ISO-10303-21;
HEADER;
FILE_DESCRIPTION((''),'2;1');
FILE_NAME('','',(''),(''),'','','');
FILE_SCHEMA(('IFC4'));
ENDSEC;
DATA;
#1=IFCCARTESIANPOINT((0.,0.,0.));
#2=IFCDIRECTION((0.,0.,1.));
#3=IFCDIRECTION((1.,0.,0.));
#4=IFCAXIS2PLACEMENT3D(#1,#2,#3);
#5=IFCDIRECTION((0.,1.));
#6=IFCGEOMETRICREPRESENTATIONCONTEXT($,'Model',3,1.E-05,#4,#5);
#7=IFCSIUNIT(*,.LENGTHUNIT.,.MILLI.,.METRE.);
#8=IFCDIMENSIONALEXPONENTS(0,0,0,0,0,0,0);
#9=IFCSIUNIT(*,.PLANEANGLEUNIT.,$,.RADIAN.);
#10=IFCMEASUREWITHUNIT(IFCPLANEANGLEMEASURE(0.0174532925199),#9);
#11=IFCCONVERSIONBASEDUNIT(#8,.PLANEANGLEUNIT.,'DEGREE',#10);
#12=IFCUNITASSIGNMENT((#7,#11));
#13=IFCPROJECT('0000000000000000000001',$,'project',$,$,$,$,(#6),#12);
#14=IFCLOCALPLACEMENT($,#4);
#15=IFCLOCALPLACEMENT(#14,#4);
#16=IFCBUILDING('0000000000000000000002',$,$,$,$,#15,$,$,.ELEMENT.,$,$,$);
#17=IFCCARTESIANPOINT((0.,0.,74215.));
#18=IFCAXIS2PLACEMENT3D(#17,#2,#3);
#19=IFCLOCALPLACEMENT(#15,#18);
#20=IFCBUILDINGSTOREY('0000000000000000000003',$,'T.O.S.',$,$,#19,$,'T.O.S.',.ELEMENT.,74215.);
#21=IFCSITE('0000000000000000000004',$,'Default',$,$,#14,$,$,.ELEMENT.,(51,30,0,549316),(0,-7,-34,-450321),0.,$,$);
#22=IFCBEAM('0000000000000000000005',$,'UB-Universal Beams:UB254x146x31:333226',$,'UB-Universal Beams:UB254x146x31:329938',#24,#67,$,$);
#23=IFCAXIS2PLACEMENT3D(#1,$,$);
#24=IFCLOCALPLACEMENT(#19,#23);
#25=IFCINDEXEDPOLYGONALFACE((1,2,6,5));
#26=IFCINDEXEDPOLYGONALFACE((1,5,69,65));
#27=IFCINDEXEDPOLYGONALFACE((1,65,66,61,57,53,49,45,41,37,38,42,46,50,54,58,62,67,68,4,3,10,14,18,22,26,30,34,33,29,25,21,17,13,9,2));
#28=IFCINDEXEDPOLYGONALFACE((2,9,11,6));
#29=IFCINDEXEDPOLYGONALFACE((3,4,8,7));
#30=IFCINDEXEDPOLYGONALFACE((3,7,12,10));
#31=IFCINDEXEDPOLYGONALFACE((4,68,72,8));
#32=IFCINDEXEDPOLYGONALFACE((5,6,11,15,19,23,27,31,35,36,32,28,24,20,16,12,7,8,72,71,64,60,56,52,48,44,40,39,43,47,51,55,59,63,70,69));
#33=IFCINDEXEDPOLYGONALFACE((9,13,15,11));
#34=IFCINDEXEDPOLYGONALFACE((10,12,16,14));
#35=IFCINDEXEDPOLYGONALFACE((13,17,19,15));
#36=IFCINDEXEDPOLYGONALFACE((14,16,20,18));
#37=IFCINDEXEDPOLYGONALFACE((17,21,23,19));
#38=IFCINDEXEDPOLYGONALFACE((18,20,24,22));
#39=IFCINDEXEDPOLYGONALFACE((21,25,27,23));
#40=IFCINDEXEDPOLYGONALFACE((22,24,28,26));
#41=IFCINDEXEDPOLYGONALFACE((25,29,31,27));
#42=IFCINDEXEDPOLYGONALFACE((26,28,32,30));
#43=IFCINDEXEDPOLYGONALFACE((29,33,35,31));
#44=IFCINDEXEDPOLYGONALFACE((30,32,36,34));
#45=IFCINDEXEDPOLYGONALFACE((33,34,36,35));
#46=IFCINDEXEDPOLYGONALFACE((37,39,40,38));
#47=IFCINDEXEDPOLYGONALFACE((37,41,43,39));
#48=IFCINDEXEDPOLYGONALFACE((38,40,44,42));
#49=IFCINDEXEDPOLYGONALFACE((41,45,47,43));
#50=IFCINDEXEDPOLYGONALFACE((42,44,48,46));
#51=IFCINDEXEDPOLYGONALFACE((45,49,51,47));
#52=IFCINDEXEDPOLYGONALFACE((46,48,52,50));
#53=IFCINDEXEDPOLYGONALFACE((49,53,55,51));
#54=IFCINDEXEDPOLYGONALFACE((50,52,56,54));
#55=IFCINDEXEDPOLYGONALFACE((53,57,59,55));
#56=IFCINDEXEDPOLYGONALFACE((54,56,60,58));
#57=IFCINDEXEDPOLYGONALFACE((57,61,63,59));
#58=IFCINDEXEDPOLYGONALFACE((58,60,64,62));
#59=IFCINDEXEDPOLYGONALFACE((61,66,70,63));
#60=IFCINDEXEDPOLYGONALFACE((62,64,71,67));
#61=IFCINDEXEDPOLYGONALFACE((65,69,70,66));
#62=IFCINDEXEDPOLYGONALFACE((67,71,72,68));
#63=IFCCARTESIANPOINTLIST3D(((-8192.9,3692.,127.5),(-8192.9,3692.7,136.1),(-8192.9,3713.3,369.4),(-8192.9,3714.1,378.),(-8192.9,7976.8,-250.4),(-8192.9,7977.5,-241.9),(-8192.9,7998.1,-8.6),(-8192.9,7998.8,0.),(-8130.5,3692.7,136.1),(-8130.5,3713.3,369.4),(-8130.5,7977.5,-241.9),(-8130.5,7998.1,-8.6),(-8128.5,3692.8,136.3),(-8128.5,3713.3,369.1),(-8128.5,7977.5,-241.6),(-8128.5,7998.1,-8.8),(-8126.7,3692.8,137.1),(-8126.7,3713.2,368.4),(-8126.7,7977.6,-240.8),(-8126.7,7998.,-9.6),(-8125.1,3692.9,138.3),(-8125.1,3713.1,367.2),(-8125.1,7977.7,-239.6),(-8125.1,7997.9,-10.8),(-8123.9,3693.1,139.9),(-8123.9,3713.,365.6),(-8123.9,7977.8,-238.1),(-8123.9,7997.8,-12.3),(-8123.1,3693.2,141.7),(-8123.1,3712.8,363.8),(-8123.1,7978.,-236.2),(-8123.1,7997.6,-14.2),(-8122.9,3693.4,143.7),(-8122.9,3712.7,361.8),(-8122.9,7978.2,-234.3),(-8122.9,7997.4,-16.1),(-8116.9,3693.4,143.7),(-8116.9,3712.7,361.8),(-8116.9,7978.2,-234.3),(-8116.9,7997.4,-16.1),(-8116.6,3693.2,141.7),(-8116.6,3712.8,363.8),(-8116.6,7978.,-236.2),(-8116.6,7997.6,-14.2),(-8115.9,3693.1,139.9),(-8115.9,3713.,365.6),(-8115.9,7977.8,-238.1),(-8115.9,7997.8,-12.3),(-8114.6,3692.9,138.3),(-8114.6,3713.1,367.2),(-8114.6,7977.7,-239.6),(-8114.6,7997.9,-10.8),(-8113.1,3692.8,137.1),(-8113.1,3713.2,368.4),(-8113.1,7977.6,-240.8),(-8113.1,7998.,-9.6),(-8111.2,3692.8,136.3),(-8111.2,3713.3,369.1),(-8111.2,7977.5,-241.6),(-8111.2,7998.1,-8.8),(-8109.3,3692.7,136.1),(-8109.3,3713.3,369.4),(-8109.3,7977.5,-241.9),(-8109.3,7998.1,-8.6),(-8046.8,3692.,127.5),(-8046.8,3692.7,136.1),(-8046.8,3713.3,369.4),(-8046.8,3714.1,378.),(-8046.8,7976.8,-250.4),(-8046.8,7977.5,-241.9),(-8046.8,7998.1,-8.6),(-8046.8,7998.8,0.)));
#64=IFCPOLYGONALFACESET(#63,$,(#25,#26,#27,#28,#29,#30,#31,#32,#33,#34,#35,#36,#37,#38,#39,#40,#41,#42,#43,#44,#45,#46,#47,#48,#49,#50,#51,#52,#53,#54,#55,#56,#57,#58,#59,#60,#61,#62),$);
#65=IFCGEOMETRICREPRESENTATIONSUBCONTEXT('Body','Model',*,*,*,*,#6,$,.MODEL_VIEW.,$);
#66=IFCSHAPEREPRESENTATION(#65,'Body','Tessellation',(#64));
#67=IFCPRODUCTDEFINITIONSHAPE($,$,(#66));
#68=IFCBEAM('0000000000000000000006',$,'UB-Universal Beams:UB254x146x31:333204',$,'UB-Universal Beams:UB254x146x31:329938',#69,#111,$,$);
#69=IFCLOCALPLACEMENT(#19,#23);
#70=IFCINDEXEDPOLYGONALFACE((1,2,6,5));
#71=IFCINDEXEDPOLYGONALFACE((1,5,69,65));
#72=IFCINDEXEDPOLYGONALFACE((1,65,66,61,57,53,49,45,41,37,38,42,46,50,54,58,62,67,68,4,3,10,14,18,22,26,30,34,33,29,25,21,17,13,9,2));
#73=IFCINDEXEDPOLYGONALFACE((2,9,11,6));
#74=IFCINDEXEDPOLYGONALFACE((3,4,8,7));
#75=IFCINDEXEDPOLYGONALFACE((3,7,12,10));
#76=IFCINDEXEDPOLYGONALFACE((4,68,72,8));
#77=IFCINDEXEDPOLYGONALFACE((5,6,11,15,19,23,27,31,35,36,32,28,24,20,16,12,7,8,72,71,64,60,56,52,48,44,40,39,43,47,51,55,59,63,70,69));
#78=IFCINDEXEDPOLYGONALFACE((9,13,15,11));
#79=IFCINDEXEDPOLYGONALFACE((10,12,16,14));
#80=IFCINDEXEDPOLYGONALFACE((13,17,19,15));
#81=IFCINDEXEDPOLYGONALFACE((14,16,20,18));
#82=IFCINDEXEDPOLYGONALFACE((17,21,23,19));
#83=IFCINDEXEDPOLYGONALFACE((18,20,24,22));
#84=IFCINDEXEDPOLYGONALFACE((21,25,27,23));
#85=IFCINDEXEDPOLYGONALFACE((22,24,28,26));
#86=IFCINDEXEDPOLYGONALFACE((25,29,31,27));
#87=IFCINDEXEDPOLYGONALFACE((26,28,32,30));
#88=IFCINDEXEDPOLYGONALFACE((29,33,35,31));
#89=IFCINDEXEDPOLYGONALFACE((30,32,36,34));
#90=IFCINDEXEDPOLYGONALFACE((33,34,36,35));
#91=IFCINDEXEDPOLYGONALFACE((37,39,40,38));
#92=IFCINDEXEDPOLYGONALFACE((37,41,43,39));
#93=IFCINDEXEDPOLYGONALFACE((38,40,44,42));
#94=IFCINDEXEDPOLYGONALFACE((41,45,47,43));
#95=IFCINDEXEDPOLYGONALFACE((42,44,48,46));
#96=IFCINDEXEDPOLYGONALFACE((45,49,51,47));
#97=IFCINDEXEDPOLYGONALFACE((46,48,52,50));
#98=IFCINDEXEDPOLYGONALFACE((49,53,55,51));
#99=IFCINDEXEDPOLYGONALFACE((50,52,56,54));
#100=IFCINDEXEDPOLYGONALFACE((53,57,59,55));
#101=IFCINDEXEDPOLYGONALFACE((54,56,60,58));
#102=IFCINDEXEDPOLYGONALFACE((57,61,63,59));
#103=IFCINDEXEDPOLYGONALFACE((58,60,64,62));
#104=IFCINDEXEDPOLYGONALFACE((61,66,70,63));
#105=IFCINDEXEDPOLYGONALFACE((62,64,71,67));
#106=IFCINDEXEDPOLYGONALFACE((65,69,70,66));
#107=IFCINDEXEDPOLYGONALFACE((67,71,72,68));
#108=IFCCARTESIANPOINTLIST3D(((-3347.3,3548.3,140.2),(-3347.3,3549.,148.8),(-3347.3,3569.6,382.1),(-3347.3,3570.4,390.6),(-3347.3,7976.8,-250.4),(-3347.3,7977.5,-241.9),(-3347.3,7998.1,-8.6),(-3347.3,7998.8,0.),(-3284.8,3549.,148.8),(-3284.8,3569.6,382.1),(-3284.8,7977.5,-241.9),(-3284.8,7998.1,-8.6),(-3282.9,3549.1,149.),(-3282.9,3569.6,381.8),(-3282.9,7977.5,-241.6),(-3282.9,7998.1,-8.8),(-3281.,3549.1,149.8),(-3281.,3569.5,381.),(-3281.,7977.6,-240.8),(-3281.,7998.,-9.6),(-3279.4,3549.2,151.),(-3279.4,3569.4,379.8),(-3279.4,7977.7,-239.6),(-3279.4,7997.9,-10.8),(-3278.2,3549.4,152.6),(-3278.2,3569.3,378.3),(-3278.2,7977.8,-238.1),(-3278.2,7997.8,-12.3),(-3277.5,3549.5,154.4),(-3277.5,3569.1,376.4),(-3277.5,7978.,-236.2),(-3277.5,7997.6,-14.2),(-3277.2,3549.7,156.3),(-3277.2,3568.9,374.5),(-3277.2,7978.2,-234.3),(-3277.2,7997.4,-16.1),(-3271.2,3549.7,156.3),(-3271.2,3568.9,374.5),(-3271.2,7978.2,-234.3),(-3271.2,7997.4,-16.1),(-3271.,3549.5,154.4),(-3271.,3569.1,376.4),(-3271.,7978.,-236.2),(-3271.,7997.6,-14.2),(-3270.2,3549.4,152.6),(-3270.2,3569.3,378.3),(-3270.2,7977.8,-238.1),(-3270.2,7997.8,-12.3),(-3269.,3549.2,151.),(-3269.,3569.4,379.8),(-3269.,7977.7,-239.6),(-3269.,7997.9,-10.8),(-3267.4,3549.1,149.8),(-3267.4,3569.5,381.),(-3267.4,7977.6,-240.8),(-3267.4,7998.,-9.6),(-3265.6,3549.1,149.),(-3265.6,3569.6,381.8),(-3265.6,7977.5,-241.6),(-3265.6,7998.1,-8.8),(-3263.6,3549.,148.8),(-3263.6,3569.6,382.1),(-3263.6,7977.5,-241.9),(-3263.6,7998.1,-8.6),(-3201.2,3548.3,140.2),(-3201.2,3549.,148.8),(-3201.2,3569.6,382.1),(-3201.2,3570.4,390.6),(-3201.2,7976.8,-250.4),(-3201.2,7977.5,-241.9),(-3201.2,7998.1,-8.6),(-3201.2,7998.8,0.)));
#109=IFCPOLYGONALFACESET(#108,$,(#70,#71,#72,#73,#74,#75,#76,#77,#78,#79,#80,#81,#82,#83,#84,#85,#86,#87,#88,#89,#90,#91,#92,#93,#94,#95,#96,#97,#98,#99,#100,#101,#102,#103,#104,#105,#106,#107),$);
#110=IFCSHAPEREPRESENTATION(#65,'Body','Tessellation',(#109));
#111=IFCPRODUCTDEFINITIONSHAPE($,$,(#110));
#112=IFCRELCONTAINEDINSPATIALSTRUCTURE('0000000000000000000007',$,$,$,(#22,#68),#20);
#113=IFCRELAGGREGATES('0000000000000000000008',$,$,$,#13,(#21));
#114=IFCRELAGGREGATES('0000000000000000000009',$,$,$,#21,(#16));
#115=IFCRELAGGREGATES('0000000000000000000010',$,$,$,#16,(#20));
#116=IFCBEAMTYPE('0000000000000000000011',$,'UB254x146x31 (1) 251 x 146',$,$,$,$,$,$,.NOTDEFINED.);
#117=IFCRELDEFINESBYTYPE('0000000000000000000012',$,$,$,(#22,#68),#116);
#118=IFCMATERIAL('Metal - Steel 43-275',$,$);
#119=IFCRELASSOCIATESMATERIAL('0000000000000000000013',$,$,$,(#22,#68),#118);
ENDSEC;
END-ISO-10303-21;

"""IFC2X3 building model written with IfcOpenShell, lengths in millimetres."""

from ifc_helpers import new_model, entity, si_unit, converted_unit, point, direction, frame, frame_2d, origin_with_axes, place, context, subcontext, project, spatial, polyline, circle_curve, parameter, trimmed, segment, composite_curve, outline, extrude, clip, halfspace, material, type_object, element, save


model = new_model("IFC2X3")

# Units and contexts
model_context = context("Model", 3, precision=1e-05, world=origin_with_axes(), true_north=direction((0.0, 1.0)))
body_context = subcontext(model_context, "Body", "Model", "MODEL_VIEW")
ifc_project = project(units=[si_unit("LENGTHUNIT", "METRE", prefix="MILLI"), converted_unit("PLANEANGLEUNIT", "DEGREE", entity("IfcPlaneAngleMeasure", 0.0174532925199), si_unit("PLANEANGLEUNIT", "RADIAN"), dimensions=[0, 0, 0, 0, 0, 0, 0])], contexts=[model_context])

# Site, building, storey
site_placement = place(None, origin_with_axes())
site = spatial("IfcSite", under=ifc_project, at=site_placement, Name="Default", CompositionType="ELEMENT", RefLatitude=(51, 30, 0, 549316), RefLongitude=(0, -7, -34, -450321), RefElevation=0.0)
building_placement = place(site_placement, origin_with_axes())
building = spatial("IfcBuilding", under=site, at=building_placement, CompositionType="ELEMENT")
storey_placement = place(building_placement, frame((0.0, 0.0, 74215.0), z_axis=(0.0, 0.0, 1.0), x_axis=(1.0, 0.0, 0.0)))
storey = spatial("IfcBuildingStorey", under=building, at=storey_placement, Name="T.O.S.", LongName="T.O.S.", CompositionType="ELEMENT", Elevation=74215.0)

# Beams
ifc_material = material(Name="Metal - Steel 43-275")
beam_type_1 = type_object("IfcBeamType", Name="UB254x146x31 (1) 251 x 146", PredefinedType="NOTDEFINED")
beam_1_placement = place(storey_placement, frame((-8119.9, 3684.9, 254.3), z_axis=(0.0, 0.0, 1.0), x_axis=(1.0, 0.0, 0.0)))
element("IfcBeam", 1, at=beam_1_placement, inside=storey, type_object=beam_type_1, material=ifc_material, Name="UB-Universal Beams:UB254x146x31:333226", ObjectType="UB-Universal Beams:UB254x146x31:329938", context=body_context, shape_type="Clipping", body=[
    clip(clip(clip(clip(extrude(outline(composite_curve([segment(polyline([(125.7, 73.0), (117.1, 73.0), (117.1, 10.6)]), True, "CONTINUOUS"), segment(trimmed(circle_curve(frame_2d((109.5, 10.6), x_axis=(0.0, -1.0)), 7.6), [point((117.1, 10.6)), parameter(90.0)], [point((109.5, 3.0)), parameter(0.0)], False, "CARTESIAN"), True, "CONTINUOUS"), segment(polyline([(109.5, 3.0), (-109.5, 3.0)]), True, "CONTINUOUS"), segment(trimmed(circle_curve(frame_2d((-109.5, 10.6), x_axis=(-1.0, 0.0)), 7.6), [point((-109.5, 3.0)), parameter(90.0)], [point((-117.1, 10.6)), parameter(0.0)], False, "CARTESIAN"), True, "CONTINUOUS"), segment(polyline([(-117.1, 10.6), (-117.1, 73.0), (-125.7, 73.0), (-125.7, -73.0), (-117.1, -73.0), (-117.1, -10.6)]), True, "CONTINUOUS"), segment(trimmed(circle_curve(frame_2d((-109.5, -10.6), x_axis=(0.0, 1.0)), 7.6), [point((-117.1, -10.6)), parameter(90.0)], [point((-109.5, -3.0)), parameter(0.0)], False, "CARTESIAN"), True, "CONTINUOUS"), segment(polyline([(-109.5, -3.0), (109.5, -3.0)]), True, "CONTINUOUS"), segment(trimmed(circle_curve(frame_2d((109.5, -10.6), x_axis=(1.0, 0.0)), 7.6), [point((109.5, -3.0)), parameter(90.0)], [point((117.1, -10.6)), parameter(0.0)], False, "CARTESIAN"), True, "CONTINUOUS"), segment(polyline([(117.1, -10.6), (117.1, -73.0), (125.7, -73.0), (125.7, 73.0)]), True, "CONTINUOUS")], self_intersect=False)), frame((0.0, 4339.2, -382.8), z_axis=(0.0, -0.996132, 0.087866), x_axis=(0.0, -0.087866, -0.996132)), (0.0, 0.0, 1.0), 4374.3), halfspace(frame((0.0, 4302.9, -379.5), z_axis=(0.0, -0.996132, 0.087866), x_axis=(0.0, -0.087866, -0.996132)), True)), halfspace(frame((0.0, 18.2, -1.6), z_axis=(0.0, 0.996132, -0.087866), x_axis=(0.0, 0.087866, 0.996132)), True)), halfspace(frame((0.0, 4321.1, 0.0), z_axis=(0.0, -1.0, 0.0), x_axis=(0.0, 0.0, -1.0)), True)), halfspace(frame((0.0, 0.0, 0.0), z_axis=(0.0, 1.0, 0.0), x_axis=(0.0, 0.0, 1.0)), True)),
])
beam_2_placement = place(storey_placement, frame((-3274.2, 3541.2, 267.0), z_axis=(0.0, 0.0, 1.0), x_axis=(1.0, 0.0, 0.0)))
element("IfcBeam", 2, at=beam_2_placement, inside=storey, type_object=beam_type_1, material=ifc_material, Name="UB-Universal Beams:UB254x146x31:333204", ObjectType="UB-Universal Beams:UB254x146x31:329938", context=body_context, shape_type="Clipping", body=[
    clip(clip(clip(clip(extrude(outline(composite_curve([segment(polyline([(125.7, 73.0), (117.1, 73.0), (117.1, 10.6)]), True, "CONTINUOUS"), segment(trimmed(circle_curve(frame_2d((109.5, 10.6), x_axis=(0.0, -1.0)), 7.6), [point((117.1, 10.6)), parameter(90.0)], [point((109.5, 3.0)), parameter(0.0)], False, "CARTESIAN"), True, "CONTINUOUS"), segment(polyline([(109.5, 3.0), (-109.5, 3.0)]), True, "CONTINUOUS"), segment(trimmed(circle_curve(frame_2d((-109.5, 10.6), x_axis=(-1.0, 0.0)), 7.6), [point((-109.5, 3.0)), parameter(90.0)], [point((-117.1, 10.6)), parameter(0.0)], False, "CARTESIAN"), True, "CONTINUOUS"), segment(polyline([(-117.1, 10.6), (-117.1, 73.0), (-125.7, 73.0), (-125.7, -73.0), (-117.1, -73.0), (-117.1, -10.6)]), True, "CONTINUOUS"), segment(trimmed(circle_curve(frame_2d((-109.5, -10.6), x_axis=(0.0, 1.0)), 7.6), [point((-117.1, -10.6)), parameter(90.0)], [point((-109.5, -3.0)), parameter(0.0)], False, "CARTESIAN"), True, "CONTINUOUS"), segment(polyline([(-109.5, -3.0), (109.5, -3.0)]), True, "CONTINUOUS"), segment(trimmed(circle_curve(frame_2d((109.5, -10.6), x_axis=(1.0, 0.0)), 7.6), [point((109.5, -3.0)), parameter(90.0)], [point((117.1, -10.6)), parameter(0.0)], False, "CARTESIAN"), True, "CONTINUOUS"), segment(polyline([(117.1, -10.6), (117.1, -73.0), (125.7, -73.0), (125.7, 73.0)]), True, "CONTINUOUS")], self_intersect=False)), frame((0.0, 4482.9, -395.4), z_axis=(0.0, -0.996132, 0.087866), x_axis=(0.0, -0.087866, -0.996132)), (0.0, 0.0, 1.0), 4518.6), halfspace(frame((0.0, 4446.6, -392.2), z_axis=(0.0, -0.996132, 0.087866), x_axis=(0.0, -0.087866, -0.996132)), True)), halfspace(frame((0.0, 18.2, -1.6), z_axis=(0.0, 0.996132, -0.087866), x_axis=(0.0, 0.087866, 0.996132)), True)), halfspace(frame((0.0, 4464.8, 0.0), z_axis=(0.0, -1.0, 0.0), x_axis=(0.0, 0.0, -1.0)), True)), halfspace(frame((0.0, 0.0, 0.0), z_axis=(0.0, 1.0, 0.0), x_axis=(0.0, 0.0, 1.0)), True)),
])

save(model, "model.ifc")
